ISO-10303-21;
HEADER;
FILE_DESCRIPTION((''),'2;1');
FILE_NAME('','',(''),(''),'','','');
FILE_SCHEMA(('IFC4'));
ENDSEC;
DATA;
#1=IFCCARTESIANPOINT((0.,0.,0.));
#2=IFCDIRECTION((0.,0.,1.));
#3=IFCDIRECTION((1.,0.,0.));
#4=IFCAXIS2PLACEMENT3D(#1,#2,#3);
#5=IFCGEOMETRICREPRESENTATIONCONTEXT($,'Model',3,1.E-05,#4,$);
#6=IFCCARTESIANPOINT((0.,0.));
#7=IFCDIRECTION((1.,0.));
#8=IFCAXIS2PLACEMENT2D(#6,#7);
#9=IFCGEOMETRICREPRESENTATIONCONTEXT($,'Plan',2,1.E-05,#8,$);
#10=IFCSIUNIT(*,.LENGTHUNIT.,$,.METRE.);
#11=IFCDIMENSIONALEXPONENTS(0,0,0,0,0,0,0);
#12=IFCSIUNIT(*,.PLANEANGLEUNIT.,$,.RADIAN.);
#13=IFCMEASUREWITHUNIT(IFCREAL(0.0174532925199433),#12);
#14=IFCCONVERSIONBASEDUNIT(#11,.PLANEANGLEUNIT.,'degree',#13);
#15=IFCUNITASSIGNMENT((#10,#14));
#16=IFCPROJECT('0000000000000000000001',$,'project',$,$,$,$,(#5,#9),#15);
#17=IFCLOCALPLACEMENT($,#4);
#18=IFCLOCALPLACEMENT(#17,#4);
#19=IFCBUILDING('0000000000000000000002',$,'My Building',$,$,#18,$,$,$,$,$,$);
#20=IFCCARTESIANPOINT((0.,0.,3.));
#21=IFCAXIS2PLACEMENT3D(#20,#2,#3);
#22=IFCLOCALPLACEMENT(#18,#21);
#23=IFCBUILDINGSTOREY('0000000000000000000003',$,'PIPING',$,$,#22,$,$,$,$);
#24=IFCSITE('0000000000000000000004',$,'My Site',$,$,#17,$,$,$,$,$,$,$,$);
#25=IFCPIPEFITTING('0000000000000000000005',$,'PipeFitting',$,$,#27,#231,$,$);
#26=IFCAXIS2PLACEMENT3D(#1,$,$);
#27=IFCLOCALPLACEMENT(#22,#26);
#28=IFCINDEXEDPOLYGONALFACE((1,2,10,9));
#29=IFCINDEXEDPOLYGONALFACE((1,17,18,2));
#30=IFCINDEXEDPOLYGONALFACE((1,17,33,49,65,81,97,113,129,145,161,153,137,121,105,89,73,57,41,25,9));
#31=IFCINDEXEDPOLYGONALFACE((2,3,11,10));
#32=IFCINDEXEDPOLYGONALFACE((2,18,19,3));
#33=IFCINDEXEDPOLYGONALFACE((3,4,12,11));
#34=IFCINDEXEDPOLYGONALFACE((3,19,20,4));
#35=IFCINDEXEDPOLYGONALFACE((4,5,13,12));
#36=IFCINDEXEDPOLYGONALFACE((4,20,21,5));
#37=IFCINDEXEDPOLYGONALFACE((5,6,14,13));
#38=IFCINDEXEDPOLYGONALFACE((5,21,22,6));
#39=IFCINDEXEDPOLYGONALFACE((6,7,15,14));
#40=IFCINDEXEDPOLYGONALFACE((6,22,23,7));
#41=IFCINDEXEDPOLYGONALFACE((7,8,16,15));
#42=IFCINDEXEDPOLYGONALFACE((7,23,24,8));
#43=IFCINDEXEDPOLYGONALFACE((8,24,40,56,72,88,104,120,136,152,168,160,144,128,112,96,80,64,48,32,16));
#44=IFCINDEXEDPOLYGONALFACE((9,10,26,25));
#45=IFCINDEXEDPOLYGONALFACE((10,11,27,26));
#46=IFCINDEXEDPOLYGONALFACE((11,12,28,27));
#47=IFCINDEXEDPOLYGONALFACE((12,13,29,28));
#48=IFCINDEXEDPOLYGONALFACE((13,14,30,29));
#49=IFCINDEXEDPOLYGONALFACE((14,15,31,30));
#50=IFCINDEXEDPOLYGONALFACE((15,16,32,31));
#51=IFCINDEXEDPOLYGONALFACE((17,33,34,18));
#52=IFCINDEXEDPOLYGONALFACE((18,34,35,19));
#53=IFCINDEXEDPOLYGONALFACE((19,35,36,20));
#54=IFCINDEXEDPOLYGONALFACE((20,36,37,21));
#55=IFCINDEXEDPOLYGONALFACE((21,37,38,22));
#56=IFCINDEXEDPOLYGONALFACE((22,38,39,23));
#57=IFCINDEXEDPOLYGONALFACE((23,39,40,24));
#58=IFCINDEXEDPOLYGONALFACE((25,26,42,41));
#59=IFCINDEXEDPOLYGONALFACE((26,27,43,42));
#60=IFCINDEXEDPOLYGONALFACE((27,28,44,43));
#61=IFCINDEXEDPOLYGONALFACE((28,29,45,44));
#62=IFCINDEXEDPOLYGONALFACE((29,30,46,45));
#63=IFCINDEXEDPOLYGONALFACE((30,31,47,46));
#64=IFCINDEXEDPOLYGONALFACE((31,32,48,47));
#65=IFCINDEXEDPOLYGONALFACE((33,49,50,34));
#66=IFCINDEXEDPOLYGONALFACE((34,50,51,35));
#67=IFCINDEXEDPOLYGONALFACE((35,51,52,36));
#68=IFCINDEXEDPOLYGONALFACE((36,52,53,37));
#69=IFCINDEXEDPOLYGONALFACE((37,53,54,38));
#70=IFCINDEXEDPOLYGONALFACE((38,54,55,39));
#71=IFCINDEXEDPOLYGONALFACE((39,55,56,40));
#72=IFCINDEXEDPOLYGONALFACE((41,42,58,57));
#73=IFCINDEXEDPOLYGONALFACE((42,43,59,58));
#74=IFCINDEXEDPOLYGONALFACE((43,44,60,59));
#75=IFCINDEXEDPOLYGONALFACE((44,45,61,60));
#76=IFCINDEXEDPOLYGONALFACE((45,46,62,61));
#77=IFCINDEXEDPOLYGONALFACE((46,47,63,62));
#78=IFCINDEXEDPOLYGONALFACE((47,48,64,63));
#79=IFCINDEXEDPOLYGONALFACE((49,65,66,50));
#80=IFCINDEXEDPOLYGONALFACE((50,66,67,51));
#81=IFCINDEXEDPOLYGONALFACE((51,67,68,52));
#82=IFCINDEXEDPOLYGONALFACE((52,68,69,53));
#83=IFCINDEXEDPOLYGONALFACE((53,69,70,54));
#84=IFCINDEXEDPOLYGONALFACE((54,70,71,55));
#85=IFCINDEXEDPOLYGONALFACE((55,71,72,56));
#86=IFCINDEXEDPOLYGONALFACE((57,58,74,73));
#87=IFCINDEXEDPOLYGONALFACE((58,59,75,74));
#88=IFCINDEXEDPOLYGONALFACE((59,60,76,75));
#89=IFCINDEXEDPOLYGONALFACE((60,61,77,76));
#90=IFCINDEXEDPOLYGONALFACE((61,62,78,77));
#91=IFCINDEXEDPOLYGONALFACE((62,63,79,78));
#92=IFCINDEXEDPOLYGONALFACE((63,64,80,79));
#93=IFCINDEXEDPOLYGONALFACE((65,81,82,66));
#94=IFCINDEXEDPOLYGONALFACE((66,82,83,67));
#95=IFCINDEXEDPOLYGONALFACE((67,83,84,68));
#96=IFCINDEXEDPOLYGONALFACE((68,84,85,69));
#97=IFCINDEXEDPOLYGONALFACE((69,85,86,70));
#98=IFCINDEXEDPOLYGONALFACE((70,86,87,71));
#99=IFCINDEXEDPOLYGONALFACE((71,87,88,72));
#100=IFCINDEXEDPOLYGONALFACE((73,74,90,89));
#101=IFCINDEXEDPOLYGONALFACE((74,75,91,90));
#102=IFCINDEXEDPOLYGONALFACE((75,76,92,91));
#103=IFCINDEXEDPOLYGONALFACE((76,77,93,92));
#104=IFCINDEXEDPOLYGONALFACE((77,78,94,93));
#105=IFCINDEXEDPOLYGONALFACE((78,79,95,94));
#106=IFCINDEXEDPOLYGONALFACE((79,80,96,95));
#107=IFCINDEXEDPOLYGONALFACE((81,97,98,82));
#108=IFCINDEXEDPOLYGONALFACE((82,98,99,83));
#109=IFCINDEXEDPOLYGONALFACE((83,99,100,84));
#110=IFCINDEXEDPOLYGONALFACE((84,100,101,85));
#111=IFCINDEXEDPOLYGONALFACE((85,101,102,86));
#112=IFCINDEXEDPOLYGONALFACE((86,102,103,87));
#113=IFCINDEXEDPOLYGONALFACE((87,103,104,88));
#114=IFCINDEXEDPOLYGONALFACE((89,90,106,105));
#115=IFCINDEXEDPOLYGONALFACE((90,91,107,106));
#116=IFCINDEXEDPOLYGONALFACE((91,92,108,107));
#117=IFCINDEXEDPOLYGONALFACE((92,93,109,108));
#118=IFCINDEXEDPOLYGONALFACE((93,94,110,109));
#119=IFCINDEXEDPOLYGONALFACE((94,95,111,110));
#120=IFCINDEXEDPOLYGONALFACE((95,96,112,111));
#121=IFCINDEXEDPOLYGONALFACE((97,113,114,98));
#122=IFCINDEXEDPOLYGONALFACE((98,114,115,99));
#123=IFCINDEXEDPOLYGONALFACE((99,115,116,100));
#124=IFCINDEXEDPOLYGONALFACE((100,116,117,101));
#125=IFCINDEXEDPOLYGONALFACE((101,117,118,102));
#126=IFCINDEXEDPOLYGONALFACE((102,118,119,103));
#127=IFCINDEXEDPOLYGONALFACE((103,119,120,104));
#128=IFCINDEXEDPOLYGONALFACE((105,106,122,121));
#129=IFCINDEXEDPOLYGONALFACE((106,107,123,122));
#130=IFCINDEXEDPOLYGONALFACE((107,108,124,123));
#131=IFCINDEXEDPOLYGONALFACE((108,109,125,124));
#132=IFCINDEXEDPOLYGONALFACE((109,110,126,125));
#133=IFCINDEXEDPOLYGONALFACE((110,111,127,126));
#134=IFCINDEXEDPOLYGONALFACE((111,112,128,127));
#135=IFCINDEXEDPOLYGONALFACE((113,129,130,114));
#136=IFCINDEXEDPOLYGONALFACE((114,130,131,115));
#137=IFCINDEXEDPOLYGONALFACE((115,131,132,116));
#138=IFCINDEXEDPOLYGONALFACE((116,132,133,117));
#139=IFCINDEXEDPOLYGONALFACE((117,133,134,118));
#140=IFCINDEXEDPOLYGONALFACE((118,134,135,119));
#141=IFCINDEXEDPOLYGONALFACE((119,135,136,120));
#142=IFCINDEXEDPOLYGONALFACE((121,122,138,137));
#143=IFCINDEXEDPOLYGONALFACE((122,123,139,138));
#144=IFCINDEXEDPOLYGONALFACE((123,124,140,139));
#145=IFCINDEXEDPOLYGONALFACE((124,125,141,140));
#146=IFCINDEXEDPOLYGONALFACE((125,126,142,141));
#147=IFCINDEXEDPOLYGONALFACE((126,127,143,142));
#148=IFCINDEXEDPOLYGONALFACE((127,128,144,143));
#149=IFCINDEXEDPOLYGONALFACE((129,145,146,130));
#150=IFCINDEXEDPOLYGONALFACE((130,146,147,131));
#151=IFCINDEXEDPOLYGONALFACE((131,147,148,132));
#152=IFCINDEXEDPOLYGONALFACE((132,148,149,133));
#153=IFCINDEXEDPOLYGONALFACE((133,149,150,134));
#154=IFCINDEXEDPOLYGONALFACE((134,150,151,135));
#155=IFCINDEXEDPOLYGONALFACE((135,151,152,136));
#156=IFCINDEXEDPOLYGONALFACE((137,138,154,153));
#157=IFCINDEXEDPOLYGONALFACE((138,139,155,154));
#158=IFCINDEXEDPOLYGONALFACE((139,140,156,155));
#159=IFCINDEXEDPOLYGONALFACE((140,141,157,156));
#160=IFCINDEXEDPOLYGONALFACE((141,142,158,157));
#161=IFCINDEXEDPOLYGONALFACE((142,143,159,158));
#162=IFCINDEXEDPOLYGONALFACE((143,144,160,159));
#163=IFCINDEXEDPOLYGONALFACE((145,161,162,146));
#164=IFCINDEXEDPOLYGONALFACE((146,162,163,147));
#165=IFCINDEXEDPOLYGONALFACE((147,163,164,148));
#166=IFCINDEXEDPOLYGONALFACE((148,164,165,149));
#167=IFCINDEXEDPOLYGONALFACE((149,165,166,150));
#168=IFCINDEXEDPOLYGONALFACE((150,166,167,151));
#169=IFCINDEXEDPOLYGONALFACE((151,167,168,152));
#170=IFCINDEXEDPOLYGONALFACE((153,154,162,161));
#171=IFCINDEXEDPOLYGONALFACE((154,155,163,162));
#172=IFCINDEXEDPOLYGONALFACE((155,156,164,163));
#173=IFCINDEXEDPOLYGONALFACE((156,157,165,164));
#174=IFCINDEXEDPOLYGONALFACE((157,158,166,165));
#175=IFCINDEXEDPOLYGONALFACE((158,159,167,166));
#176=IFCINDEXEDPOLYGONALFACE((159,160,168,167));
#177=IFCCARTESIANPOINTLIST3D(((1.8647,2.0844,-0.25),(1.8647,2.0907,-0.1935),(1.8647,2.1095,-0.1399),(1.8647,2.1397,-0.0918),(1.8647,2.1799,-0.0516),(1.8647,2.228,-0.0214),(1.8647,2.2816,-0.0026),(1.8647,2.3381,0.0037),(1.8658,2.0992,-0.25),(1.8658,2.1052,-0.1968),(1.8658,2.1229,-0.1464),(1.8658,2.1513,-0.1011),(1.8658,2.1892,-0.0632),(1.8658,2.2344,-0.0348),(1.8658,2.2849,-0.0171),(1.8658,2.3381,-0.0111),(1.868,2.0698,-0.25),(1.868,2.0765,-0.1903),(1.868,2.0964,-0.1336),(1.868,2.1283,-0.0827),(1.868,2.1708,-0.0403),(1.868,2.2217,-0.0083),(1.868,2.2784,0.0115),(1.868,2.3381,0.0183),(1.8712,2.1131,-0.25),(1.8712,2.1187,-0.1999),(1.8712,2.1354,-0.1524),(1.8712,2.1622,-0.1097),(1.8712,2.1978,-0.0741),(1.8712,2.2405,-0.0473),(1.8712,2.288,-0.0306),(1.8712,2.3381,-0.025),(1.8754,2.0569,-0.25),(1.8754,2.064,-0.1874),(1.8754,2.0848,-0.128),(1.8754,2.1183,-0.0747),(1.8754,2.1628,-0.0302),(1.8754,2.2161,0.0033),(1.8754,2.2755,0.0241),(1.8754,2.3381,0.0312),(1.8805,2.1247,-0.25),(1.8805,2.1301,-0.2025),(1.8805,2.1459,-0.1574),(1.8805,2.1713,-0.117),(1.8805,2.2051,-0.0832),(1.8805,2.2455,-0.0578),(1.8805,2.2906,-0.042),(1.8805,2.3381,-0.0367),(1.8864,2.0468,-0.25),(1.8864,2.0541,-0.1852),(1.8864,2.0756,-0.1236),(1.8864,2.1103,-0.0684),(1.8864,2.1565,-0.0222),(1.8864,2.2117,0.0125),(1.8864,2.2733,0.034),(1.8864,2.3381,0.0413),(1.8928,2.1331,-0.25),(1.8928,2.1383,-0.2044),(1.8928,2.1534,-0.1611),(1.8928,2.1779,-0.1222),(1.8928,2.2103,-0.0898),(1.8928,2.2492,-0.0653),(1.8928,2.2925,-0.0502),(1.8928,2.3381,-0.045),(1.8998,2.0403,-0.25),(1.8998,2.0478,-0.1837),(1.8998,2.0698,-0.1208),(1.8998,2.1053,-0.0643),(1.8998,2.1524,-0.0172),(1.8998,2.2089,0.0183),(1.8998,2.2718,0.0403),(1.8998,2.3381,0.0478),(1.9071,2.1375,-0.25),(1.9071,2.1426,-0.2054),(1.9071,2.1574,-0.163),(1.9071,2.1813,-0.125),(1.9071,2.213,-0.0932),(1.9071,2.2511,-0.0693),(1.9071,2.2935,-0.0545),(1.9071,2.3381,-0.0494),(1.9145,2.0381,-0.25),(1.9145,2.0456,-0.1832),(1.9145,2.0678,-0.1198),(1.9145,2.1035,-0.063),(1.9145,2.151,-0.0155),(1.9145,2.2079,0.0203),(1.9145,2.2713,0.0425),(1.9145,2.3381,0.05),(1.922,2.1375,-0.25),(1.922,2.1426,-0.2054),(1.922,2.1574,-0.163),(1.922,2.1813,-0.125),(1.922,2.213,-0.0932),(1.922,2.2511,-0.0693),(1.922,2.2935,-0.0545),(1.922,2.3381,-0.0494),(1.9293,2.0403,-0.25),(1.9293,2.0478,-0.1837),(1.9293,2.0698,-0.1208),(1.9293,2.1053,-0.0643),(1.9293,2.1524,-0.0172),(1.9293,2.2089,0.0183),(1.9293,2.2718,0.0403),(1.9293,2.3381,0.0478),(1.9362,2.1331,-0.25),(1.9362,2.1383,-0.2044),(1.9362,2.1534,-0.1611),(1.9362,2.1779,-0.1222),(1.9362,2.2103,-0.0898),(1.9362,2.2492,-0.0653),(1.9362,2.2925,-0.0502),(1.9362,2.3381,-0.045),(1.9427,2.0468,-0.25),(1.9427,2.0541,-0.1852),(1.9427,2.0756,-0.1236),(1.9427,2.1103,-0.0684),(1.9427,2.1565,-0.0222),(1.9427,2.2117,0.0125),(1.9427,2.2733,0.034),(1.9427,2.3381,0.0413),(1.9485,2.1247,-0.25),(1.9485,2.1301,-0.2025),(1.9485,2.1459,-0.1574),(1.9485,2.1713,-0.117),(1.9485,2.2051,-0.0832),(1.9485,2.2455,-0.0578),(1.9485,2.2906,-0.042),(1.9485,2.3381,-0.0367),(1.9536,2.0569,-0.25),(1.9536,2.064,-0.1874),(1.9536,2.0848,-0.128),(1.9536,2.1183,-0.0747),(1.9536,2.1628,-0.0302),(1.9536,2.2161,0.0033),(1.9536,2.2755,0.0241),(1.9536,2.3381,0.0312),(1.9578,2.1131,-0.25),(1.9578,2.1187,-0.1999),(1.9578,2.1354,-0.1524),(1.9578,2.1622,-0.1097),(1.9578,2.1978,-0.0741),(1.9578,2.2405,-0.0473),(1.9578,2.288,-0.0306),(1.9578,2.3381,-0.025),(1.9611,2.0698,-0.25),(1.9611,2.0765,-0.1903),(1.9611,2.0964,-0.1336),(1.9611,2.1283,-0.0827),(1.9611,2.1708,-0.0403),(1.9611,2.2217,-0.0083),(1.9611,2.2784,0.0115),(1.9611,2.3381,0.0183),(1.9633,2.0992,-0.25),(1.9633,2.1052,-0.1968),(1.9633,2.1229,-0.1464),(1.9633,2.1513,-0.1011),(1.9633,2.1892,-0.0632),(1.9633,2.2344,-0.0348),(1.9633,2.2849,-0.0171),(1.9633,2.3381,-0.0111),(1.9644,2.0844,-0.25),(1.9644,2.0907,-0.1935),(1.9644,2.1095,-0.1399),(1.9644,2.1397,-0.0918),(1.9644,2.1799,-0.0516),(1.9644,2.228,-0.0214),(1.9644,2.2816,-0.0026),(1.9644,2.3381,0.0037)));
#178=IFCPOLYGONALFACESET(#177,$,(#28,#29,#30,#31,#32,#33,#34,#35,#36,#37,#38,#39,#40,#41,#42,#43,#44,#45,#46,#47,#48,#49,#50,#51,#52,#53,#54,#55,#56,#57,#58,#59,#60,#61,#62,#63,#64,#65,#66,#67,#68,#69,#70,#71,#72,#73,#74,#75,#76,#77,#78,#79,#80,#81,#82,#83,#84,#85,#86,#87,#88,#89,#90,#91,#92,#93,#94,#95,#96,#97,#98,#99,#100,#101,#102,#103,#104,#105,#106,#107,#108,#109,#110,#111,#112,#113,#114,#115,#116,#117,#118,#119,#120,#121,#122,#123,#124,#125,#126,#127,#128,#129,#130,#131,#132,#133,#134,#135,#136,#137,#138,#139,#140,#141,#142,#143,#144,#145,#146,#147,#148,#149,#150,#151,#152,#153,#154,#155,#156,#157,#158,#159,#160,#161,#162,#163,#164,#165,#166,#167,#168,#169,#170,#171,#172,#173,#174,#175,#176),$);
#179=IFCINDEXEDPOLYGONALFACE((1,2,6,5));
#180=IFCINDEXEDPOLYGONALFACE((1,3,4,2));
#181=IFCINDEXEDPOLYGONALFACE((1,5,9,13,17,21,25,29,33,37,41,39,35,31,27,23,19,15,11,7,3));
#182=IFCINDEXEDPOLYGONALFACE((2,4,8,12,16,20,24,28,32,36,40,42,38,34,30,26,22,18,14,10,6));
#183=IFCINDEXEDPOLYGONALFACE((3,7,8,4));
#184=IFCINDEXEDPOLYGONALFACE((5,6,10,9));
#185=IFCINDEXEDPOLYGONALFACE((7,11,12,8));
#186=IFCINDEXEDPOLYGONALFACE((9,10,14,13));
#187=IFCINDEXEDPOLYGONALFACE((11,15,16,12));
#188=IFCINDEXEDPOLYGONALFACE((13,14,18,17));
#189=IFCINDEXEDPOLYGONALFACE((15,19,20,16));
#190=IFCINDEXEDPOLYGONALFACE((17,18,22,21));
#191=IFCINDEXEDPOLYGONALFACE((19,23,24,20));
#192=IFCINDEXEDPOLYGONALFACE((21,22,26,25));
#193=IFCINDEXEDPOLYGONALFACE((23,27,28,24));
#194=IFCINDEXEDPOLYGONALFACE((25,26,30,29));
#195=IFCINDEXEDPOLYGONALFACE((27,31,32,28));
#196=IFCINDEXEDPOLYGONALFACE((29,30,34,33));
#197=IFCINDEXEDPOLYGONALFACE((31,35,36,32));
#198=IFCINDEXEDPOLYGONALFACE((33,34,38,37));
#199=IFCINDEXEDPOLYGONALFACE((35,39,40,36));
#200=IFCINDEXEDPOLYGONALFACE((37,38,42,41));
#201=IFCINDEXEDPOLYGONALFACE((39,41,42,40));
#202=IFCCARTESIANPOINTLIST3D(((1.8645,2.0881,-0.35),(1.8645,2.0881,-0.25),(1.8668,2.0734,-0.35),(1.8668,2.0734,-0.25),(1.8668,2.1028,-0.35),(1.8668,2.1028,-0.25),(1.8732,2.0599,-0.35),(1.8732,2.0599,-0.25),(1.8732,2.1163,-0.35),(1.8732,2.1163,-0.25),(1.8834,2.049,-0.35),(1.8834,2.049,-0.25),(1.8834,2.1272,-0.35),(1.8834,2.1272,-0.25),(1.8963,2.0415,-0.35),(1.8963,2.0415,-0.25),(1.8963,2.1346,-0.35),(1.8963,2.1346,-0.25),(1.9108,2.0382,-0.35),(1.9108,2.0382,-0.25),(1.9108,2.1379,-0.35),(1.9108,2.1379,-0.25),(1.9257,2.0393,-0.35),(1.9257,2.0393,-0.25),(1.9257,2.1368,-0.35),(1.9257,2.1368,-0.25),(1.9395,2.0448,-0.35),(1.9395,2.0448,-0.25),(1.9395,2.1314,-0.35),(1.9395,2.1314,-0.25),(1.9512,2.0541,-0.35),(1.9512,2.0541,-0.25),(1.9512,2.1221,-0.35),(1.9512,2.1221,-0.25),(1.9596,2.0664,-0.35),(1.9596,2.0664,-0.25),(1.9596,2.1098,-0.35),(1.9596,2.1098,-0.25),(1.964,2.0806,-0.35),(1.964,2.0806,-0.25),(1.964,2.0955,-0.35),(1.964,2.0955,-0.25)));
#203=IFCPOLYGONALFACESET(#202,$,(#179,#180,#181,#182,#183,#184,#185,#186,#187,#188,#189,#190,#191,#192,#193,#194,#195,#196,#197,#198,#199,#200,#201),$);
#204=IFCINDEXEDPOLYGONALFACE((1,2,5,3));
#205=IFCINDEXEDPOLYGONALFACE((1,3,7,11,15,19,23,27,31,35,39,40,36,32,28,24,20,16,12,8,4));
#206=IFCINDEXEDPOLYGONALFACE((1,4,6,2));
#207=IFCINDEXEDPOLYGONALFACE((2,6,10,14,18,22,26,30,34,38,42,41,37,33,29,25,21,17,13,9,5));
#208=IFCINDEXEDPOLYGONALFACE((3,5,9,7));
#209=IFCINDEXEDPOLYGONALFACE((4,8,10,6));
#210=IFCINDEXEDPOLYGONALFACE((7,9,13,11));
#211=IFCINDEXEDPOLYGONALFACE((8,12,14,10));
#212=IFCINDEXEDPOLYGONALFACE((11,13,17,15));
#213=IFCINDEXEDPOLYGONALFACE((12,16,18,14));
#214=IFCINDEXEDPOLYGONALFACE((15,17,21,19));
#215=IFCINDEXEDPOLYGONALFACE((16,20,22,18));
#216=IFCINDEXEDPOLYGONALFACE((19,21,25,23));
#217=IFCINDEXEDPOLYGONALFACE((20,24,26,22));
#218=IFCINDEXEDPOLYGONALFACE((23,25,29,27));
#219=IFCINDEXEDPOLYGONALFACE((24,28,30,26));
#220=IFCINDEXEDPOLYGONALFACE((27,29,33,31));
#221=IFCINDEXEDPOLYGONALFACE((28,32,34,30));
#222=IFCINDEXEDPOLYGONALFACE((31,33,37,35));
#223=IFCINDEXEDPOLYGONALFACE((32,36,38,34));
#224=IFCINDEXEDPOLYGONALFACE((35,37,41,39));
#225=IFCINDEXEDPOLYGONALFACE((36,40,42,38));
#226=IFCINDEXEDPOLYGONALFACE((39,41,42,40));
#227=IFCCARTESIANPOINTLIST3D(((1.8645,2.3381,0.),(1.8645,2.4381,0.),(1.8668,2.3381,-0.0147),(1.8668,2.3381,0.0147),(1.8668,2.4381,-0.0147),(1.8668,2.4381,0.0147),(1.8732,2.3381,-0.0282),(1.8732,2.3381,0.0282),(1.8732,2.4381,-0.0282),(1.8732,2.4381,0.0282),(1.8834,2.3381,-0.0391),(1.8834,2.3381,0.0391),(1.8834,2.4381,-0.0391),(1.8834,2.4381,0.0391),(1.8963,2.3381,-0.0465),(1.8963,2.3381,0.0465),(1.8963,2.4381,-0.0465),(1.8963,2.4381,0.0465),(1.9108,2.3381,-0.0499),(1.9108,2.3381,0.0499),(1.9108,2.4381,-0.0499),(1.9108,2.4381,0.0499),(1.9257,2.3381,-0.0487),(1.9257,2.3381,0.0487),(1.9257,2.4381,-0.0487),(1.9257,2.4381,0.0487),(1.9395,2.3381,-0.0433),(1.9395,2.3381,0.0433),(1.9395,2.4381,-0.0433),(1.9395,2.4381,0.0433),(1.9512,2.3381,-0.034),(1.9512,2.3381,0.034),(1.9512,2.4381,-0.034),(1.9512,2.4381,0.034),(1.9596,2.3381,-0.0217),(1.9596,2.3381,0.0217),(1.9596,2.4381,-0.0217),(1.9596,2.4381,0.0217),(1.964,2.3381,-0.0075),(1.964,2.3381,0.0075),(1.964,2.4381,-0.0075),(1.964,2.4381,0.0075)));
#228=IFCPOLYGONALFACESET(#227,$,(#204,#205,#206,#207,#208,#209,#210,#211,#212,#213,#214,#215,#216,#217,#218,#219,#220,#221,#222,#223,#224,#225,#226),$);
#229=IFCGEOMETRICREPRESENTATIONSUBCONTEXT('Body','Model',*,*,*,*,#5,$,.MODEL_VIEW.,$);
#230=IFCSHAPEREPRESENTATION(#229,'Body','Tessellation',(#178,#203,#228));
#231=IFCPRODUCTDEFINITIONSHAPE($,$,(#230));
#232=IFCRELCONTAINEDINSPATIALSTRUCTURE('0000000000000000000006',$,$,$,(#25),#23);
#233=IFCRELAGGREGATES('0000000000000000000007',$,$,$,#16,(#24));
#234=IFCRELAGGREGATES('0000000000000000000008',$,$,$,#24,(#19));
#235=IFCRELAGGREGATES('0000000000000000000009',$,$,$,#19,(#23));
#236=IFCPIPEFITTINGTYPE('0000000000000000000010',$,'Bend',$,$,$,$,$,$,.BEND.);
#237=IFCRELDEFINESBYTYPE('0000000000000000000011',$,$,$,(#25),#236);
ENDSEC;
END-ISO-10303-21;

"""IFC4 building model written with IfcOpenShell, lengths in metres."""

from ifc_helpers import new_model, entity, si_unit, converted_unit, frame, origin_with_axes, origin_2d_with_axis, place, context, subcontext, project, spatial, circle, extrude, source, transform, mapped, type_object, type_shapes, element, save


model = new_model("IFC4")

# Units and contexts
model_context = context("Model", 3, precision=1e-05, world=origin_with_axes())
plan_context = context("Plan", 2, precision=1e-05, world=origin_2d_with_axis())
body_context = subcontext(model_context, "Body", "Model", "MODEL_VIEW")
ifc_project = project(units=[si_unit("LENGTHUNIT", "METRE"), converted_unit("PLANEANGLEUNIT", "degree", entity("IfcReal", 0.0174532925199433), si_unit("PLANEANGLEUNIT", "RADIAN"), dimensions=[0, 0, 0, 0, 0, 0, 0])], contexts=[model_context, plan_context])

# Site, building, storey
site_placement = place(None, origin_with_axes())
site = spatial("IfcSite", under=ifc_project, at=site_placement, Name="My Site")
building_placement = place(site_placement, origin_with_axes())
building = spatial("IfcBuilding", under=site, at=building_placement, Name="My Building")
storey_placement = place(building_placement, frame((0.0, 0.0, 3.0), z_axis=(0.0, 0.0, 1.0), x_axis=(1.0, 0.0, 0.0)))
storey = spatial("IfcBuildingStorey", under=building, at=storey_placement, Name="PIPING")

# Pipe fitting
pipe_fitting_type = type_object("IfcPipeFittingType", Name="Bend", PredefinedType="BEND")
shared_shape = source(origin_with_axes(), body_context, "Body", "SolidModel", [
    entity("IfcSweptDiskSolid", entity("IfcIndexedPolyCurve", entity("IfcCartesianPointList3D", [[0.0, 0.0, 0.1], [0.0, -0.0732, 0.2768], [0.0, -0.25, 0.35]]), [entity("IfcArcIndex", [1, 2, 3])]), 0.05),
    extrude(circle(Radius=0.05), origin_with_axes(), (0.0, 0.0, 1.0), 0.1),
    extrude(circle(Radius=0.05), frame((0.0, -0.25, 0.35), z_axis=(0.0, -1.0, 0.0), x_axis=(1.0, 0.0, 0.0)), (0.0, 0.0, 1.0), 0.1),
])
type_shapes(pipe_fitting_type, [shared_shape])
for number, where, z_axis, x_axis, name in (
    (1, (1.9145, 2.0881, -0.35), (0.0, 0.0, 1.0), (-1.0, 0.0, 0.0), "PipeFitting"),
):
    element("IfcPipeFitting", number, at=place(storey_placement, frame(where, z_axis=z_axis, x_axis=x_axis)), inside=storey, type_object=pipe_fitting_type, Name=name, context=body_context, shape_type="MappedRepresentation", body=[
        mapped(shared_shape, transform((0.0, 0.0, 0.0), x_axis=(1.0, 0.0, 0.0), y_axis=(0.0, 1.0, 0.0), z_axis=(0.0, 0.0, 1.0), scale=1.0)),
    ])

save(model, "model.ifc")
